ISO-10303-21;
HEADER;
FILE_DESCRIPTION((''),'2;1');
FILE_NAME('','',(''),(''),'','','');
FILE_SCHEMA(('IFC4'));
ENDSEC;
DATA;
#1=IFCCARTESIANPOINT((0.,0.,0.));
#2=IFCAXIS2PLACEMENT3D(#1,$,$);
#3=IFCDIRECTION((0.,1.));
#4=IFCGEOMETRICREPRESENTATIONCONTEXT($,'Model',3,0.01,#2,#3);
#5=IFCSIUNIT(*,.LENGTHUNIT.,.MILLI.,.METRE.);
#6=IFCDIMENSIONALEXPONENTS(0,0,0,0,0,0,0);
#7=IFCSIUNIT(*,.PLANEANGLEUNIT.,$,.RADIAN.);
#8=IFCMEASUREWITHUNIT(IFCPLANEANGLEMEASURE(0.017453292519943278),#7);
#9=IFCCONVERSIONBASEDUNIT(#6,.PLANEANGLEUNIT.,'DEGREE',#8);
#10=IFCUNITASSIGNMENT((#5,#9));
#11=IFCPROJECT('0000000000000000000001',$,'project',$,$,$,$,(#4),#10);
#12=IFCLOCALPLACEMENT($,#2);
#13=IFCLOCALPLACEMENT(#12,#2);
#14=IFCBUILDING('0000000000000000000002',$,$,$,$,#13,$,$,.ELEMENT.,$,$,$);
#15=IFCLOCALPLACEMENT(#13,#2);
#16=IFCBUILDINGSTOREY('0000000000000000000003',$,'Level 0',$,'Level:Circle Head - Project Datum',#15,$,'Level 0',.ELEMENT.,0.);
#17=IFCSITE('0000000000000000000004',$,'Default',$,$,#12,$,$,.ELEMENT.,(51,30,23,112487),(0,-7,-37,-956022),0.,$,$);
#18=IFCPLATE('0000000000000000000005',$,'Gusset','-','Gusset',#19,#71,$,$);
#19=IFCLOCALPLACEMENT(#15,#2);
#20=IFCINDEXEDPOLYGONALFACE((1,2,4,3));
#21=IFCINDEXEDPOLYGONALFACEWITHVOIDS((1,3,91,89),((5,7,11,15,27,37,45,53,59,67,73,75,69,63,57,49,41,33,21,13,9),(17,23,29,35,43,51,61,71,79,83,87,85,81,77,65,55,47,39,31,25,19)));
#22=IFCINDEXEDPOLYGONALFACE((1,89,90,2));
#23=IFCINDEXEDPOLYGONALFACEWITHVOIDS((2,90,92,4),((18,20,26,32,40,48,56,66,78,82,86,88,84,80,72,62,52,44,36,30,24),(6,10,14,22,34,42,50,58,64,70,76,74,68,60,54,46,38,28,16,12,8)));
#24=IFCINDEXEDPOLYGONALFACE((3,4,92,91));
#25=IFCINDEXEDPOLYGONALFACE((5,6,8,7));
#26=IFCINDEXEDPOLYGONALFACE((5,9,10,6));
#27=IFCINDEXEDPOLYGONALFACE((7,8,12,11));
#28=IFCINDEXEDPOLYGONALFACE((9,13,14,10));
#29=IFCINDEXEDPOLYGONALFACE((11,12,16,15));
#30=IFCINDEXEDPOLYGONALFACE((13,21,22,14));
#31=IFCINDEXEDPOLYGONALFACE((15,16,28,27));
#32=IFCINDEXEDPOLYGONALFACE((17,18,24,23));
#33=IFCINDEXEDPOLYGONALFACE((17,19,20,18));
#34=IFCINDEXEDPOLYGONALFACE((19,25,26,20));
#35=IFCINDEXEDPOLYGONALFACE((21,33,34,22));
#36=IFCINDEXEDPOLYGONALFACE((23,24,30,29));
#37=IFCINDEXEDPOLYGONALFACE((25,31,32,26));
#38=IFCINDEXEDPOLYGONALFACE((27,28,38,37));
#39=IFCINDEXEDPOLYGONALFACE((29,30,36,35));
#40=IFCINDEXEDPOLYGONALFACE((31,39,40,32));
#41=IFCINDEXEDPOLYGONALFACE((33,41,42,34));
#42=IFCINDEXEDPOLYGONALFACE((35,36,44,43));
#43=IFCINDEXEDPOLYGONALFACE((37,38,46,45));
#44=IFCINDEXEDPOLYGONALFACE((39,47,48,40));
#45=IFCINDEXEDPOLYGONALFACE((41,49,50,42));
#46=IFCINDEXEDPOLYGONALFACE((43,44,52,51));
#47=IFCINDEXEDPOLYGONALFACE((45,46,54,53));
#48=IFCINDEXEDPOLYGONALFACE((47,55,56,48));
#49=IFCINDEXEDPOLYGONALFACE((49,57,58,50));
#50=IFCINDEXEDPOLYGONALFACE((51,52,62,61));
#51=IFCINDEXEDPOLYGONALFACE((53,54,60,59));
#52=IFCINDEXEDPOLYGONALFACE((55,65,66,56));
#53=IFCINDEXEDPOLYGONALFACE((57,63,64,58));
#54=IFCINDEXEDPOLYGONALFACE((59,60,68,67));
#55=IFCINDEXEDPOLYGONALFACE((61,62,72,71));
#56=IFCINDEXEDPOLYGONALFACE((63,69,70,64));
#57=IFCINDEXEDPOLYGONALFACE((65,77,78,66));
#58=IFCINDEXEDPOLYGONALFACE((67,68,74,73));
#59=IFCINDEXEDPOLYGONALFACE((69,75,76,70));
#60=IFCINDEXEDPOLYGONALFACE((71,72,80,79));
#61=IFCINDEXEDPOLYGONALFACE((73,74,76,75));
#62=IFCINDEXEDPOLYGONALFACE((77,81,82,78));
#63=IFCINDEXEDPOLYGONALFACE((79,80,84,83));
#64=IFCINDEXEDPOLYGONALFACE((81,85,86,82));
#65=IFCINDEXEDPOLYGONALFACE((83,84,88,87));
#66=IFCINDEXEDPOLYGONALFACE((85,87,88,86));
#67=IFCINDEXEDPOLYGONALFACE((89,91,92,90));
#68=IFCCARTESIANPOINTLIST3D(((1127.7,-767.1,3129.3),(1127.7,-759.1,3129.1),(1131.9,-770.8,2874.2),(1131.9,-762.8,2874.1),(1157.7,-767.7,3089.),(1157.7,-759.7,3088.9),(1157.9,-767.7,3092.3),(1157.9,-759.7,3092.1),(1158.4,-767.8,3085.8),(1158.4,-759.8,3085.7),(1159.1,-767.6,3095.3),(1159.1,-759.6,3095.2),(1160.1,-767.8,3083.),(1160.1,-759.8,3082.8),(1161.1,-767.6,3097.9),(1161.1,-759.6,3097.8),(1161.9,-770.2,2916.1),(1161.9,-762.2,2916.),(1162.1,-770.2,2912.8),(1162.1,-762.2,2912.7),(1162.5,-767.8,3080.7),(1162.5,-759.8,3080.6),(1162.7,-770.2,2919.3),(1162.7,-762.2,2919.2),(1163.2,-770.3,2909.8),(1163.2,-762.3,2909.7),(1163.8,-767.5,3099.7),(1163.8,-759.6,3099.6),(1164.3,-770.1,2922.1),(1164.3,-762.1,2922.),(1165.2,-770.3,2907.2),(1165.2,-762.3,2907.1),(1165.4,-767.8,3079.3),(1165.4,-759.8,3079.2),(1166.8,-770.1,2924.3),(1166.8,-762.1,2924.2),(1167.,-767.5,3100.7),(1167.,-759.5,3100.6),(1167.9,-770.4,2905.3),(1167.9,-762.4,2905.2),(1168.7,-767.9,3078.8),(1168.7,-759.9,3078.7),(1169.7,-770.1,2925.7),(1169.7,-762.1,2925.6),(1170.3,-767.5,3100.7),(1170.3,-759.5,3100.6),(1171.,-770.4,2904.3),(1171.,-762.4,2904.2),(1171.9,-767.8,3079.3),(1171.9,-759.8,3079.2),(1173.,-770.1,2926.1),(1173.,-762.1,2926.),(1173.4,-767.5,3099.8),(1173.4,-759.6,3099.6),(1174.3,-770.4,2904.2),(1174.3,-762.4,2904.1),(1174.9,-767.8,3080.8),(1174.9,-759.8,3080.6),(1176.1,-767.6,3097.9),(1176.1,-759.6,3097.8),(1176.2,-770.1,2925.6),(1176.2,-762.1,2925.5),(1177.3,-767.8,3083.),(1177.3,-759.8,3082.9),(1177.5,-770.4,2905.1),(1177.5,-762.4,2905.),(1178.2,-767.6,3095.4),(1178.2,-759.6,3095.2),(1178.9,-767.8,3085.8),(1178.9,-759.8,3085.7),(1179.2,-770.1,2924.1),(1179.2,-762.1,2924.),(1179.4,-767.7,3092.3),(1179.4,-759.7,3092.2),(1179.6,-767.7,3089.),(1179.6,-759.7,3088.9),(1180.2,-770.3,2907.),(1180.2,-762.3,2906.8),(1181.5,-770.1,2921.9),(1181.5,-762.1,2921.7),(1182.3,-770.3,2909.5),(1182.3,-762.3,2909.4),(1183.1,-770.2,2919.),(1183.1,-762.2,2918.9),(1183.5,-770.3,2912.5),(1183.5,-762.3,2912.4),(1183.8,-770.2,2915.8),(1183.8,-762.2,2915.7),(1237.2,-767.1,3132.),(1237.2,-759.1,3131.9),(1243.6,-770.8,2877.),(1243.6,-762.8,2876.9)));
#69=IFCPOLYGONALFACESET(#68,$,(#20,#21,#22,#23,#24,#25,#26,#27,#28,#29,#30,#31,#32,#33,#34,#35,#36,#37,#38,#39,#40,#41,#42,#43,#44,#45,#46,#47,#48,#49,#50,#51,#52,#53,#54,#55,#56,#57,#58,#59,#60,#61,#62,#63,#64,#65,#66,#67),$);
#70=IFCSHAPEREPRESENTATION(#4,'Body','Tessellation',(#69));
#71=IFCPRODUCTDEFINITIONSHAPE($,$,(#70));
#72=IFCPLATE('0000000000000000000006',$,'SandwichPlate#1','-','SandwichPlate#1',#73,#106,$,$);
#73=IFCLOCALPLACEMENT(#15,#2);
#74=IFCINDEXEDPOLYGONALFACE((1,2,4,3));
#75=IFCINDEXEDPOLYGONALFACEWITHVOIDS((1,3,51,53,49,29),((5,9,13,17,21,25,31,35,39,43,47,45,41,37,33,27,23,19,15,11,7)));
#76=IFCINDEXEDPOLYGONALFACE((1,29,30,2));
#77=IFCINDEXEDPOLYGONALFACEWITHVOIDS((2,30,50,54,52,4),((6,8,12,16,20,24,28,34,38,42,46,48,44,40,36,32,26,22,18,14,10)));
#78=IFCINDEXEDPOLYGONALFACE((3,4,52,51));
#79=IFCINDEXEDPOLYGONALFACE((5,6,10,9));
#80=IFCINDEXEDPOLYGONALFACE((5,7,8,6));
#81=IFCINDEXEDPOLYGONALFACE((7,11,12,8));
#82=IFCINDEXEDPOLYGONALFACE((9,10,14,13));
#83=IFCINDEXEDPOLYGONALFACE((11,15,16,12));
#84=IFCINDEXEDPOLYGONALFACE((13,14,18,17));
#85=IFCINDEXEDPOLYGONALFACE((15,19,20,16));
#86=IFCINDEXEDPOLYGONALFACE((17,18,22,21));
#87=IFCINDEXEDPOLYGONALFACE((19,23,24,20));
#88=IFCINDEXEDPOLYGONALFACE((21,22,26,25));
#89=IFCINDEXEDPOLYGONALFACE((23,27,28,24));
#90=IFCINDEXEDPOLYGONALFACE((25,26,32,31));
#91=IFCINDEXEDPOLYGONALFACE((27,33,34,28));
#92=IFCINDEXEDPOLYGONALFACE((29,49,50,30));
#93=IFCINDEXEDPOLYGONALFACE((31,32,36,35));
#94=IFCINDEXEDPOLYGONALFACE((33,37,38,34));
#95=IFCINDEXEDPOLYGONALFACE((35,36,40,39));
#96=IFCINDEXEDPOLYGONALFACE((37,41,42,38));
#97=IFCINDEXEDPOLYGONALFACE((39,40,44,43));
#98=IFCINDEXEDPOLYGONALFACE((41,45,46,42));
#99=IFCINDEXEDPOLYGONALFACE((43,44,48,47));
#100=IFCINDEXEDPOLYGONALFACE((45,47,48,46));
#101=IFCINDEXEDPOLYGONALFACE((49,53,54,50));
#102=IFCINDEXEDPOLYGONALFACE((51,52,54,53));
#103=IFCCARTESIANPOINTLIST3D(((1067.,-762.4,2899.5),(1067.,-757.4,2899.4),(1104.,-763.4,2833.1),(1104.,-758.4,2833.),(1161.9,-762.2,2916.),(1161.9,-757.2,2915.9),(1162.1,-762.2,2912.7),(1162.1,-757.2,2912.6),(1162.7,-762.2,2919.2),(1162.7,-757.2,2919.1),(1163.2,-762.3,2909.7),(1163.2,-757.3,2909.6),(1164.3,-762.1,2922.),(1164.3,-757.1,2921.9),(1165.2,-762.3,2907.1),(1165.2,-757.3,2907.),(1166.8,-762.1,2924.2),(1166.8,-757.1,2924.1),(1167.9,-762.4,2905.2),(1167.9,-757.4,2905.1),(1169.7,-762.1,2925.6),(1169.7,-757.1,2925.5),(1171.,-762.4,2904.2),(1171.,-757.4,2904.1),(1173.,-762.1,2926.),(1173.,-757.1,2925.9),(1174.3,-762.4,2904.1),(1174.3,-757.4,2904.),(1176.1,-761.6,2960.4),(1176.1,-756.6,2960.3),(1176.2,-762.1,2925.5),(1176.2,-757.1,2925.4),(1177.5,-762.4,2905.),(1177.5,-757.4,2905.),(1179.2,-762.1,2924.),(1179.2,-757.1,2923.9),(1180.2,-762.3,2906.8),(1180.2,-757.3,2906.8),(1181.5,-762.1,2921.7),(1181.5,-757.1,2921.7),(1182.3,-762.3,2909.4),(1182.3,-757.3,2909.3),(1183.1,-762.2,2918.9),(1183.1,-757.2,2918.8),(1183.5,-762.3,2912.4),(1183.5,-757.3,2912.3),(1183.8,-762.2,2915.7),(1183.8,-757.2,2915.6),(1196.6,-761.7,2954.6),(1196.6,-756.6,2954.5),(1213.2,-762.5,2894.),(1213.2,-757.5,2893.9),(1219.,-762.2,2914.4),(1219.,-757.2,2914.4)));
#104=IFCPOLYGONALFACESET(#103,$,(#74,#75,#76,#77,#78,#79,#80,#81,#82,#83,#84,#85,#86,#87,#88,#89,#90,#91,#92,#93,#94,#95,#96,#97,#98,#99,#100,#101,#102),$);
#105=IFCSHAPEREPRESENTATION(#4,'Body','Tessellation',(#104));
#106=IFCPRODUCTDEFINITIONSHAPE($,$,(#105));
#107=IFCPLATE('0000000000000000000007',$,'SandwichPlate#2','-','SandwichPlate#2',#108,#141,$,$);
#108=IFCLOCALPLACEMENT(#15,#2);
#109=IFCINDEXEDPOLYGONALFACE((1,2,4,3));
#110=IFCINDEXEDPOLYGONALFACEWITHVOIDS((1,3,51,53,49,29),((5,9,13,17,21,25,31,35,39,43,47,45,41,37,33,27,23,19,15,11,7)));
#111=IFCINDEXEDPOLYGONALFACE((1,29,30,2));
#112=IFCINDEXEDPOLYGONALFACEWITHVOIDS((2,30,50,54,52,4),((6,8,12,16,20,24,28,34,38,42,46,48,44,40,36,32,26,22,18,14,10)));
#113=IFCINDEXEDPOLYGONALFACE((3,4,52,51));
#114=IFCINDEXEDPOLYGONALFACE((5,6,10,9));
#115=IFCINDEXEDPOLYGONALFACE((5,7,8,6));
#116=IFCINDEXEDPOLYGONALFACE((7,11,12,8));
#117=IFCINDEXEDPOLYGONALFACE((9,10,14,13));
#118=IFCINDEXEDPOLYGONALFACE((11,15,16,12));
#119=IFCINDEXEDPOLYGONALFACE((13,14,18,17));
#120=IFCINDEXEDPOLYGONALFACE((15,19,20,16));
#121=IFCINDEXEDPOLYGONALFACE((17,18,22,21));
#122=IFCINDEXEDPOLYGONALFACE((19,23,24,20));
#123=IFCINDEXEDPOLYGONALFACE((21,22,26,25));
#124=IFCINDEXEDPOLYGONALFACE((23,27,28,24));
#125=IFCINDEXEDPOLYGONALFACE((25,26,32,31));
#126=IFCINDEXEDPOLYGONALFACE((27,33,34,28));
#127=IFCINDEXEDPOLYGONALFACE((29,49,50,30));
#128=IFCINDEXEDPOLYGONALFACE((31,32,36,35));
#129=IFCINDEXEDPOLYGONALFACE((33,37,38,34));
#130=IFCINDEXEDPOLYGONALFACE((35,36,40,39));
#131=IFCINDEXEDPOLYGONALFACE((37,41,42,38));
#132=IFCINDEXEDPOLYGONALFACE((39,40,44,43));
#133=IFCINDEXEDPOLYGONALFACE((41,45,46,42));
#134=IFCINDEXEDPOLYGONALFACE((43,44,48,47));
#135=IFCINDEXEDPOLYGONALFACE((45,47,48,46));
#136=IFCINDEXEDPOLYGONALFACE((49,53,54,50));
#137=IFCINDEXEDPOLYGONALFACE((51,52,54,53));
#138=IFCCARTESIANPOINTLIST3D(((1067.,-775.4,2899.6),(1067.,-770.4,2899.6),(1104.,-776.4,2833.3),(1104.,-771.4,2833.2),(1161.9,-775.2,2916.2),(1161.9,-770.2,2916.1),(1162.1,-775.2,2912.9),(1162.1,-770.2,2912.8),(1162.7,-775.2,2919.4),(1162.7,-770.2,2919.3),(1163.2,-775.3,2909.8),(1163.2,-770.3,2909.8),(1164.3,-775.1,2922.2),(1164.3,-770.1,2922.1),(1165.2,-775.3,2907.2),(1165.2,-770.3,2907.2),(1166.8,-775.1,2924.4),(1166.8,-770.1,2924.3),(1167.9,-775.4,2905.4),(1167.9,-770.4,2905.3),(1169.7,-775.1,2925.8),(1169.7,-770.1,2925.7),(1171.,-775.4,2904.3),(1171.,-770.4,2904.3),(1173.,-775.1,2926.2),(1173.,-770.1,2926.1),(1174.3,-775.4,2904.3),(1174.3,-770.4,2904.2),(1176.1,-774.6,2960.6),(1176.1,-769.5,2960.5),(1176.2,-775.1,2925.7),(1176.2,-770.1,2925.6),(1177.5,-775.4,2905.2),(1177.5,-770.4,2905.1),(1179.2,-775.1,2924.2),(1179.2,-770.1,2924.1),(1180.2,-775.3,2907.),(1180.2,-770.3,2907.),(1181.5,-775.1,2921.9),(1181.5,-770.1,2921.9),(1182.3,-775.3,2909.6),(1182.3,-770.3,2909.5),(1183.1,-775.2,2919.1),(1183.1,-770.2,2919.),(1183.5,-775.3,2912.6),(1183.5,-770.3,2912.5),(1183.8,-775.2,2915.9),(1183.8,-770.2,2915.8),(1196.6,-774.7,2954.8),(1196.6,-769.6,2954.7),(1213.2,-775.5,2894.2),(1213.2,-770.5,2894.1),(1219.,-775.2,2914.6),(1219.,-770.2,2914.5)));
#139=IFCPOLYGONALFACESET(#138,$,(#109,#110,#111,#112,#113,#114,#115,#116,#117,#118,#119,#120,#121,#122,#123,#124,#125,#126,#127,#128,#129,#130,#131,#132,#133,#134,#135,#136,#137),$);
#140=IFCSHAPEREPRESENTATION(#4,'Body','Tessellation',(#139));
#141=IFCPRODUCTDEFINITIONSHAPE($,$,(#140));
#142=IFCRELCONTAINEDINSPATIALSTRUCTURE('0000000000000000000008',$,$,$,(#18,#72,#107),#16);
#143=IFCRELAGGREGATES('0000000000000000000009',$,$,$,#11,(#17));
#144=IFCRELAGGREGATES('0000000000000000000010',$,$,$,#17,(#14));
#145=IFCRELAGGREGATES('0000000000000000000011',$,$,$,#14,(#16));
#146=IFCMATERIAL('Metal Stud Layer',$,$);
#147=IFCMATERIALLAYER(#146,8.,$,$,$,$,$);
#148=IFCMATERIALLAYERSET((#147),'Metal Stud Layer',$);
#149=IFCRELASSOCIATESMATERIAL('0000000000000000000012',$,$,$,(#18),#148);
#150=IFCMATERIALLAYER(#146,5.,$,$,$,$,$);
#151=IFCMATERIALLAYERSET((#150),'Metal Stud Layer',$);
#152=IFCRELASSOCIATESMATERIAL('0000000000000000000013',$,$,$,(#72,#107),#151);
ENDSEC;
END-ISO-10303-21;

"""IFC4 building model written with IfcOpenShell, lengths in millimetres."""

from ifc_helpers import new_model, entity, si_unit, converted_unit, direction, frame, origin, origin_with_axes, origin_2d_with_axis, place, context, project, spatial, polyline, circle, outline, extrude, material, layer, layer_set, element, save


model = new_model("IFC4")

# Units and contexts
model_context = context("Model", 3, precision=0.01, world=origin(), true_north=direction((0.0, 1.0)))
ifc_project = project(units=[si_unit("LENGTHUNIT", "METRE", prefix="MILLI"), converted_unit("PLANEANGLEUNIT", "DEGREE", entity("IfcPlaneAngleMeasure", 0.017453292519943278), si_unit("PLANEANGLEUNIT", "RADIAN"), dimensions=[0, 0, 0, 0, 0, 0, 0])], contexts=[model_context])

# Site, building, storey
site_placement = place(None, origin())
site = spatial("IfcSite", under=ifc_project, at=site_placement, Name="Default", CompositionType="ELEMENT", RefLatitude=(51, 30, 23, 112487), RefLongitude=(0, -7, -37, -956022), RefElevation=0.0)
building_placement = place(site_placement, origin())
building = spatial("IfcBuilding", under=site, at=building_placement, CompositionType="ELEMENT")
storey_placement = place(building_placement, origin())
storey = spatial("IfcBuildingStorey", under=building, at=storey_placement, Name="Level 0", ObjectType="Level:Circle Head - Project Datum", LongName="Level 0", CompositionType="ELEMENT", Elevation=0.0)

# Plates, openings
ifc_material = material(Name="Metal Stud Layer")
ifc_layer_1 = layer(ifc_material, 8.0)
ifc_layer_set_1 = layer_set([ifc_layer_1], Name="Metal Stud Layer")
plate_1_placement = place(storey_placement, frame((1235.2, -767.1, 3131.9), z_axis=(0.0, 0.999896, -0.014432), x_axis=(0.02499, -0.014428, -0.999584)))
plate_1 = element("IfcPlate", 1, at=plate_1_placement, inside=storey, material=ifc_layer_set_1, Name="Gusset", Description="-", ObjectType="Gusset", context=model_context, shape_type="SweptSolid", body=[
    extrude(outline(polyline([(0.0, -2.0), (255.1, -2.0), (255.1, 109.7), (0.0, 107.5), (0.0, -2.0)])), origin_with_axes(), (0.0, 0.0, 1.0), 8.0),
])
opening_1_placement = place(plate_1_placement, frame((40.4, 67.6, 8.5), z_axis=(0.0, 0.0, -1.0), x_axis=(-0.51948, 0.854483, 0.0)))
element("IfcOpeningElement", 2, at=opening_1_placement, cuts=plate_1, ObjectType="Opening", context=model_context, shape_type="SweptSolid", body=[
    extrude(circle(Radius=11.0, at=origin_2d_with_axis()), origin(), (0.0, 0.0, 1.0), 9.0),
])
opening_2_placement = place(plate_1_placement, frame((215.2, 67.8, 8.5), z_axis=(0.0, 0.0, -1.0), x_axis=(0.465432, 0.885083, 0.0)))
element("IfcOpeningElement", 3, at=opening_2_placement, cuts=plate_1, ObjectType="Opening", context=model_context, shape_type="SweptSolid", body=[
    extrude(circle(Radius=11.0, at=origin_2d_with_axis()), origin(), (0.0, 0.0, 1.0), 9.0),
])
ifc_layer_2 = layer(ifc_material, 5.0)
ifc_layer_set_2 = layer_set([ifc_layer_2], Name="Metal Stud Layer")
plate_2_placement = place(storey_placement, frame((1226.3, -757.4, 2901.3), z_axis=(0.0, -0.999896, 0.014432), x_axis=(-0.487405, 0.012602, 0.873085)))
plate_2 = element("IfcPlate", 4, at=plate_2_placement, inside=storey, material=ifc_layer_set_2, Name="SandwichPlate#1", Description="-", ObjectType="SandwichPlate#1", context=model_context, shape_type="SweptSolid", body=[
    extrude(outline(polyline([(0.0, 0.0), (76.0, 0.0), (76.0, 140.0), (0.0, 140.0), (0.0, 0.0)])), origin_with_axes(), (0.0, 0.0, 1.0), 5.0),
])
opening_3_placement = place(plate_2_placement, frame((0.0, 0.0, 0.0), z_axis=(0.0, 0.0, 1.0), x_axis=(1.0, 0.0, 0.0)))
element("IfcOpeningElement", 5, at=opening_3_placement, cuts=plate_2, ObjectType="Opening", context=model_context, shape_type="SweptSolid", body=[
    extrude(outline(polyline([(0.0, 0.0), (15.0, 0.0), (0.0, 15.0), (0.0, 0.0)])), origin(), (0.0, 0.0, 1.0), 5.0),
])
opening_4_placement = place(plate_2_placement, frame((0.0, 0.0, 0.0), z_axis=(0.0, 0.0, 1.0), x_axis=(1.0, 0.0, 0.0)))
element("IfcOpeningElement", 6, at=opening_4_placement, cuts=plate_2, ObjectType="Opening", context=model_context, shape_type="SweptSolid", body=[
    extrude(outline(polyline([(76.0, 0.0), (76.0, 15.0), (61.0, 0.0), (76.0, 0.0)])), origin(), (0.0, 0.0, 1.0), 5.0),
])
opening_5_placement = place(plate_2_placement, frame((38.0, 40.0, -0.5), z_axis=(0.0, 0.0, 1.0), x_axis=(0.0, 1.0, 0.0)))
element("IfcOpeningElement", 7, at=opening_5_placement, cuts=plate_2, ObjectType="Opening", context=model_context, shape_type="SweptSolid", body=[
    extrude(circle(Radius=11.0, at=origin_2d_with_axis()), origin(), (0.0, 0.0, 1.0), 6.0),
])
plate_3_placement = place(storey_placement, frame((1226.3, -770.4, 2901.4), z_axis=(0.0, -0.999896, 0.014432), x_axis=(-0.487405, 0.012602, 0.873085)))
plate_3 = element("IfcPlate", 8, at=plate_3_placement, inside=storey, material=ifc_layer_set_2, Name="SandwichPlate#2", Description="-", ObjectType="SandwichPlate#2", context=model_context, shape_type="SweptSolid", body=[
    extrude(outline(polyline([(0.0, 0.0), (76.0, 0.0), (76.0, 140.0), (0.0, 140.0), (0.0, 0.0)])), origin_with_axes(), (0.0, 0.0, 1.0), 5.0),
])
opening_6_placement = place(plate_3_placement, frame((0.0, 0.0, 0.0), z_axis=(0.0, 0.0, 1.0), x_axis=(1.0, 0.0, 0.0)))
element("IfcOpeningElement", 9, at=opening_6_placement, cuts=plate_3, ObjectType="Opening", context=model_context, shape_type="SweptSolid", body=[
    extrude(outline(polyline([(0.0, 0.0), (15.0, 0.0), (0.0, 15.0), (0.0, 0.0)])), origin(), (0.0, 0.0, 1.0), 5.0),
])
opening_7_placement = place(plate_3_placement, frame((0.0, 0.0, 0.0), z_axis=(0.0, 0.0, 1.0), x_axis=(1.0, 0.0, 0.0)))
element("IfcOpeningElement", 10, at=opening_7_placement, cuts=plate_3, ObjectType="Opening", context=model_context, shape_type="SweptSolid", body=[
    extrude(outline(polyline([(76.0, 0.0), (76.0, 15.0), (61.0, 0.0), (76.0, 0.0)])), origin(), (0.0, 0.0, 1.0), 5.0),
])
opening_8_placement = place(plate_3_placement, frame((38.0, 40.0, -0.5), z_axis=(0.0, 0.0, 1.0), x_axis=(0.0, 1.0, 0.0)))
element("IfcOpeningElement", 11, at=opening_8_placement, cuts=plate_3, ObjectType="Opening", context=model_context, shape_type="SweptSolid", body=[
    extrude(circle(Radius=11.0, at=origin_2d_with_axis()), origin(), (0.0, 0.0, 1.0), 6.0),
])

save(model, "model.ifc")
